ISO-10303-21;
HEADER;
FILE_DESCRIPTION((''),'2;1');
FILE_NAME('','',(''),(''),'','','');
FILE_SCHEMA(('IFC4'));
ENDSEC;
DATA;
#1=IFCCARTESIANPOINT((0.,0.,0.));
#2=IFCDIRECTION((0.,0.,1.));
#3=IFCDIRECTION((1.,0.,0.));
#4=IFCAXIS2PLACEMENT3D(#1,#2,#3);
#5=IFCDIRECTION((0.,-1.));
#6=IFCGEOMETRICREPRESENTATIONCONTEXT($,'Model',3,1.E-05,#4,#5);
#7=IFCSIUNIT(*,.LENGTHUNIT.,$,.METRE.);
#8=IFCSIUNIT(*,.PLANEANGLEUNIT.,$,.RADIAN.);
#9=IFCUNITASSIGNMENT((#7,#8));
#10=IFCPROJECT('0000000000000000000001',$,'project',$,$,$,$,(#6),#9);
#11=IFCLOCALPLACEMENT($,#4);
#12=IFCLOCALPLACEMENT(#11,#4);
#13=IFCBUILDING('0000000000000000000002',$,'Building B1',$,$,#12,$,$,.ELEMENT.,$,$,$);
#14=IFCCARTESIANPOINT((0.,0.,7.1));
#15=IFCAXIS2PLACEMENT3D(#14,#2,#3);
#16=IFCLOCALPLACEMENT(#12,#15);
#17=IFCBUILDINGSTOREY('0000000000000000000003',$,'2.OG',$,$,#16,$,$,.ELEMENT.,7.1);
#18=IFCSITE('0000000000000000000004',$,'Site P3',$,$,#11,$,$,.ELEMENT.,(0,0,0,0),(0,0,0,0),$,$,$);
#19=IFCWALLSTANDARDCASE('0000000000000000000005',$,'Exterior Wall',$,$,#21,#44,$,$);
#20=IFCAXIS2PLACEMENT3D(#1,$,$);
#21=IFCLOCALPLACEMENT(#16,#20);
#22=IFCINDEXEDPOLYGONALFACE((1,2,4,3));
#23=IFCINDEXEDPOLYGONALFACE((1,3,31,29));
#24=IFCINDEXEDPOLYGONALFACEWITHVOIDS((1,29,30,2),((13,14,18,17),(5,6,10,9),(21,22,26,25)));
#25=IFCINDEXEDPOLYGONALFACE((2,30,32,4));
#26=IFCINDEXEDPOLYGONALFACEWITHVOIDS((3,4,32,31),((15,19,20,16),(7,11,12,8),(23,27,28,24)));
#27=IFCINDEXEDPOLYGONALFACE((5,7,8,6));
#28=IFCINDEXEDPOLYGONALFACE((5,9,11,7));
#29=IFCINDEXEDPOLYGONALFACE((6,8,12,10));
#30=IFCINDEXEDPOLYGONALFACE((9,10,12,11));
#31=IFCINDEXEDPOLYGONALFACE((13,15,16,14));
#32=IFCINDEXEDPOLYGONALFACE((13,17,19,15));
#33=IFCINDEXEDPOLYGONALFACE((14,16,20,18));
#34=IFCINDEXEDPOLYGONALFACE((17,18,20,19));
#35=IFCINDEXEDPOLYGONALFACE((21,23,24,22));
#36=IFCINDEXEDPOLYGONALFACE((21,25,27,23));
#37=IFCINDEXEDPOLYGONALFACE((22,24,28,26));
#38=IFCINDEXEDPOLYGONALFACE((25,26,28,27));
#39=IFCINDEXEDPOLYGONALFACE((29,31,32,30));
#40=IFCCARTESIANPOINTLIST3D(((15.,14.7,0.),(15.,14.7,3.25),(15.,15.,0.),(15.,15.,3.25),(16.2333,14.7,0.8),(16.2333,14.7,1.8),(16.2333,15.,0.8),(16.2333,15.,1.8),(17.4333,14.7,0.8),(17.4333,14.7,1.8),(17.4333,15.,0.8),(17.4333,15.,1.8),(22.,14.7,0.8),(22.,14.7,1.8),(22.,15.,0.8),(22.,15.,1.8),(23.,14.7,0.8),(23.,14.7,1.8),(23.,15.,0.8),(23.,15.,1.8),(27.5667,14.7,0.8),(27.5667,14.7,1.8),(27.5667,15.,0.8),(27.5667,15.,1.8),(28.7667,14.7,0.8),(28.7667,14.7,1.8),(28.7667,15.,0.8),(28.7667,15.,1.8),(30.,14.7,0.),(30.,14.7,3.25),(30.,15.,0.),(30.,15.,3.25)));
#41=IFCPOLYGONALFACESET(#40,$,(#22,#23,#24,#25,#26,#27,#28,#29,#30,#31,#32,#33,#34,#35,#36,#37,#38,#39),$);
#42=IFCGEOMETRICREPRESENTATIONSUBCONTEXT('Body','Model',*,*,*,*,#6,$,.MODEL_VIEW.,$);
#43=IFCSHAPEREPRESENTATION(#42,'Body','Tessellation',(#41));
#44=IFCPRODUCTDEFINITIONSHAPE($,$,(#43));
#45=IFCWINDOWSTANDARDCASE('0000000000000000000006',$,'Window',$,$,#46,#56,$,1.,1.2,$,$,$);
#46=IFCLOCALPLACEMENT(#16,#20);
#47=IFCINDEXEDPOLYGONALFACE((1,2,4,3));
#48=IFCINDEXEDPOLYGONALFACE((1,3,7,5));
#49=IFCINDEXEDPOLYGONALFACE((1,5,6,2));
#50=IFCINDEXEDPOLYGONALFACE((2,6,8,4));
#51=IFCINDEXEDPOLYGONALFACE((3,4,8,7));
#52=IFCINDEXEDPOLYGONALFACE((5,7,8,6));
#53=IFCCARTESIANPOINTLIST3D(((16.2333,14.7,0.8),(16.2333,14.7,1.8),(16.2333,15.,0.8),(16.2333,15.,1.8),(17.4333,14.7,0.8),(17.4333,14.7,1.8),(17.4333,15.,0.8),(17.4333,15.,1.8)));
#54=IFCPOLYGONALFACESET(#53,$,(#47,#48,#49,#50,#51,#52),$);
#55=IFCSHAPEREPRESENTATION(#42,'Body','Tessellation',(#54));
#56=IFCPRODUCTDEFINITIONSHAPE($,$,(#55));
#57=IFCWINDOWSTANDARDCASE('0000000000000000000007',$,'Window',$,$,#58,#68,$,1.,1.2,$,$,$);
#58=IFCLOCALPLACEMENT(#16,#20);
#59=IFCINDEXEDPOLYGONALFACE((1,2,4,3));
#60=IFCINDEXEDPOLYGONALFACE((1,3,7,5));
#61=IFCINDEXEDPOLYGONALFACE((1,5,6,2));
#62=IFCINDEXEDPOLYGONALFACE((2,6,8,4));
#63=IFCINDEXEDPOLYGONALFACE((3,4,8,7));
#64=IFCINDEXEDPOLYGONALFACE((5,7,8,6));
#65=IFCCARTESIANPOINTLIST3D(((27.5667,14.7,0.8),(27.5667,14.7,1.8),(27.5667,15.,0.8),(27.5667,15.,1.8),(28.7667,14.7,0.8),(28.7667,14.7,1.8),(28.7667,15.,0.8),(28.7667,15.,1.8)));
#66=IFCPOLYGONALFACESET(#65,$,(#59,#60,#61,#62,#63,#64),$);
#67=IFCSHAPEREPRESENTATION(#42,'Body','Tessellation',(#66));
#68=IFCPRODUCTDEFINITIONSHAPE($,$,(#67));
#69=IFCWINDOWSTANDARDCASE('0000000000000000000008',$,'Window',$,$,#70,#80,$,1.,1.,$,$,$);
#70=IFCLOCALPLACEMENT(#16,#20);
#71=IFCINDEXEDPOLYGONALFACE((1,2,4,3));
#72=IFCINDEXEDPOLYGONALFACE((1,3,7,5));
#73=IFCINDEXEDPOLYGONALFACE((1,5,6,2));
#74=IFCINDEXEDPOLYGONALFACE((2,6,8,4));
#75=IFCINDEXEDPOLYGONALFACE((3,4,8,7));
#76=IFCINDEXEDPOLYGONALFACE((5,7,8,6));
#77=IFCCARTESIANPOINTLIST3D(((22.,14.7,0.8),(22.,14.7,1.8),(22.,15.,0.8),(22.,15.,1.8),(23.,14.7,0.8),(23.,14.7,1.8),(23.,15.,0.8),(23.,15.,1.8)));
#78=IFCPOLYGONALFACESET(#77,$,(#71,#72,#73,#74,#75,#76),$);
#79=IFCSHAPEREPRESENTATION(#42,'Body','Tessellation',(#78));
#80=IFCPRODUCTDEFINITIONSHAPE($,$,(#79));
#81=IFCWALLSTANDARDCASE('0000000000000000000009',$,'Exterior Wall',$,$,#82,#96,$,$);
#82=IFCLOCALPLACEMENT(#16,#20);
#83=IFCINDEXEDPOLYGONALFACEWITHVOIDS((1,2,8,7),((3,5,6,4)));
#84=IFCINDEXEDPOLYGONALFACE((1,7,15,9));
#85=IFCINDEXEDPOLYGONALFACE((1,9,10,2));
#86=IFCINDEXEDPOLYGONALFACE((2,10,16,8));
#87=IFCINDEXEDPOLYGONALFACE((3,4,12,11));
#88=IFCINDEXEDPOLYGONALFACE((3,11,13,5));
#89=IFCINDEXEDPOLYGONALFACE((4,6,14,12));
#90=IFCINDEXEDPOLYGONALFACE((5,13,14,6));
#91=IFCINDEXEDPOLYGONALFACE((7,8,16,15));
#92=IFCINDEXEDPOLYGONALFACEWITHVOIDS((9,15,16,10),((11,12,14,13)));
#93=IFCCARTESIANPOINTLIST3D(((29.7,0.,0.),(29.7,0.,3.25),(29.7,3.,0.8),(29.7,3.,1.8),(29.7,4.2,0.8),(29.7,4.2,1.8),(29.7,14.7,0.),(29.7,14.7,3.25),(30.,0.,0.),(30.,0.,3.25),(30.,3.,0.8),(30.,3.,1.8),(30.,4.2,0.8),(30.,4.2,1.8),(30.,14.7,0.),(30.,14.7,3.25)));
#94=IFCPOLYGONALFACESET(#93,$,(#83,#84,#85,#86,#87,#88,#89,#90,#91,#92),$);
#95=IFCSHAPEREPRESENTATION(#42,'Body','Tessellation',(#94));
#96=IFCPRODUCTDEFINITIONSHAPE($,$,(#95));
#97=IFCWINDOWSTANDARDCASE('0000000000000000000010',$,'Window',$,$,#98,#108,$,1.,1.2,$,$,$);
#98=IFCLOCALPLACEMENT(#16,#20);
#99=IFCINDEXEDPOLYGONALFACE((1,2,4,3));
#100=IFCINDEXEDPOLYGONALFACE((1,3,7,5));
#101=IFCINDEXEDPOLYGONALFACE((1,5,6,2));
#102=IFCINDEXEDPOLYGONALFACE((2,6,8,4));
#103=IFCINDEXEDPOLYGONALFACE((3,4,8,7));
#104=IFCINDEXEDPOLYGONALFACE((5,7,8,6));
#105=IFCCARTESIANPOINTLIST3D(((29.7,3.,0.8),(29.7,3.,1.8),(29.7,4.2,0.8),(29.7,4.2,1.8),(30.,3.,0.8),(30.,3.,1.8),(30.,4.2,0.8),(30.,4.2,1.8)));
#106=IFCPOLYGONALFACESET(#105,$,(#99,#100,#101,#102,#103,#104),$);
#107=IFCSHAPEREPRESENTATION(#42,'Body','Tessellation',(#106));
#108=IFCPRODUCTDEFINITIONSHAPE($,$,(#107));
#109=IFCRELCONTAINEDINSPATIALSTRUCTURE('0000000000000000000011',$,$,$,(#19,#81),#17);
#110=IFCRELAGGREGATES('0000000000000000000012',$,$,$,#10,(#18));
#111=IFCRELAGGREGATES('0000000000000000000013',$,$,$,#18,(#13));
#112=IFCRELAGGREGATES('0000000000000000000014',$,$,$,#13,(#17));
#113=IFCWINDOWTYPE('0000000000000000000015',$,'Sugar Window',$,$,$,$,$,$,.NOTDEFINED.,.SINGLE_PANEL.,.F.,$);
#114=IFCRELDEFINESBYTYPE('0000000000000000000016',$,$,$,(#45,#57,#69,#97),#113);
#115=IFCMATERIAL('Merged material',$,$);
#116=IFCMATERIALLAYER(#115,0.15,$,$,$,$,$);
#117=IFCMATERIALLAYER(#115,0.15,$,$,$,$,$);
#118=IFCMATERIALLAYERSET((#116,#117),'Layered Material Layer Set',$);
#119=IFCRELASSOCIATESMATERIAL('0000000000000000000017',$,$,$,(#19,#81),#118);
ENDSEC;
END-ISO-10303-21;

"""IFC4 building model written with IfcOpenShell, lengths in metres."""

from ifc_helpers import new_model, si_unit, direction, frame, origin_with_axes, place, context, subcontext, project, spatial, polyline, outline, extrude, source, transform, mapped, material, layer, layer_set, layer_usage, type_object, element, fill, save


model = new_model("IFC4")

# Units and contexts
model_context = context("Model", 3, precision=1e-05, world=origin_with_axes(), true_north=direction((0.0, -1.0)))
body_context = subcontext(model_context, "Body", "Model", "MODEL_VIEW")
ifc_project = project(units=[si_unit("LENGTHUNIT", "METRE"), si_unit("PLANEANGLEUNIT", "RADIAN")], contexts=[model_context])

# Site, building, storey
site_placement = place(None, origin_with_axes())
site = spatial("IfcSite", under=ifc_project, at=site_placement, Name="Site P3", CompositionType="ELEMENT", RefLatitude=(0, 0, 0, 0), RefLongitude=(0, 0, 0, 0))
building_placement = place(site_placement, origin_with_axes())
building = spatial("IfcBuilding", under=site, at=building_placement, Name="Building B1", CompositionType="ELEMENT")
storey_placement = place(building_placement, frame((0.0, 0.0, 7.1), z_axis=(0.0, 0.0, 1.0), x_axis=(1.0, 0.0, 0.0)))
storey = spatial("IfcBuildingStorey", under=building, at=storey_placement, Name="2.OG", CompositionType="ELEMENT", Elevation=7.1)

# Wall, openings, windows
ifc_material = material(Name="Merged material")
ifc_layer_1 = layer(ifc_material, 0.15)
ifc_layer_2 = layer(ifc_material, 0.15)
ifc_layer_set_1 = layer_set([ifc_layer_1, ifc_layer_2], Name="Layered Material Layer Set")
ifc_layer_usage_1 = layer_usage(ifc_layer_set_1, "AXIS2", "POSITIVE", -0.15)
wall_1_placement = place(storey_placement, frame((30.0, 14.85, 0.0), z_axis=(0.0, 0.0, 1.0), x_axis=(-1.0, 0.0, 0.0)))
wall_1 = element("IfcWallStandardCase", 1, at=wall_1_placement, inside=storey, material=ifc_layer_usage_1, Name="Exterior Wall", context=body_context, shape_type="SweptSolid", body=[
    extrude(outline(polyline([(0.0, 0.15), (15.0, 0.15), (15.0, -0.15), (0.0, -0.15), (0.0, 0.15)])), origin_with_axes(), (0.0, 0.0, 1.0), 3.25),
])
opening_1_placement = place(wall_1_placement, frame((12.5667, 0.0, 0.8), z_axis=(0.0, 0.0, 1.0), x_axis=(1.0, 0.0, 0.0)))
opening_1 = element("IfcOpeningStandardCase", 2, at=opening_1_placement, cuts=wall_1, context=body_context, shape_type="SweptSolid", body=[
    extrude(outline(polyline([(0.0, 0.0), (0.0, 1.2), (1.0, 1.2), (1.0, 0.0), (0.0, 0.0)])), frame((0.0, -0.15, 0.0), z_axis=(0.0, 1.0, 0.0), x_axis=(0.0, 0.0, 1.0)), (0.0, 0.0, 1.0), 0.3),
])
opening_2_placement = place(wall_1_placement, frame((7.0, 0.0, 0.8), z_axis=(0.0, 0.0, 1.0), x_axis=(1.0, 0.0, 0.0)))
opening_2 = element("IfcOpeningStandardCase", 3, at=opening_2_placement, cuts=wall_1, context=body_context, shape_type="SweptSolid", body=[
    extrude(outline(polyline([(0.0, 0.0), (0.0, 1.0), (1.0, 1.0), (1.0, 0.0), (0.0, 0.0)])), frame((0.0, -0.15, 0.0), z_axis=(0.0, 1.0, 0.0), x_axis=(0.0, 0.0, 1.0)), (0.0, 0.0, 1.0), 0.3),
])
opening_3_placement = place(wall_1_placement, frame((1.2333, 0.0, 0.8), z_axis=(0.0, 0.0, 1.0), x_axis=(1.0, 0.0, 0.0)))
opening_3 = element("IfcOpeningStandardCase", 4, at=opening_3_placement, cuts=wall_1, context=body_context, shape_type="SweptSolid", body=[
    extrude(outline(polyline([(0.0, 0.0), (0.0, 1.2), (1.0, 1.2), (1.0, 0.0), (0.0, 0.0)])), frame((0.0, -0.15, 0.0), z_axis=(0.0, 1.0, 0.0), x_axis=(0.0, 0.0, 1.0)), (0.0, 0.0, 1.0), 0.3),
])
window_type = type_object("IfcWindowType", Name="Sugar Window", ParameterTakesPrecedence=False, PartitioningType="SINGLE_PANEL", PredefinedType="NOTDEFINED")
shared_shape_1 = source(origin_with_axes(), body_context, "Body", "SweptSolid", [
    extrude(outline(polyline([(0.0, 0.0), (0.0, 1.2), (1.0, 1.2), (1.0, 0.0), (0.0, 0.0)])), frame((0.0, -0.15, 0.0), z_axis=(0.0, 1.0, 0.0), x_axis=(0.0, 0.0, 1.0)), (0.0, 0.0, 1.0), 0.3),
])
window_1_placement = place(opening_1_placement, origin_with_axes())
window_1 = element("IfcWindowStandardCase", 5, at=window_1_placement, type_object=window_type, Name="Window", OverallHeight=1.0, OverallWidth=1.2, context=body_context, shape_type="MappedRepresentation", body=[
    mapped(shared_shape_1, transform((0.0, 0.0, 0.0))),
])
fill(opening_1, window_1)
window_2_placement = place(opening_3_placement, origin_with_axes())
window_2 = element("IfcWindowStandardCase", 6, at=window_2_placement, type_object=window_type, Name="Window", OverallHeight=1.0, OverallWidth=1.2, context=body_context, shape_type="MappedRepresentation", body=[
    mapped(shared_shape_1, transform((0.0, 0.0, 0.0))),
])
fill(opening_3, window_2)
shared_shape_2 = source(origin_with_axes(), body_context, "Body", "SweptSolid", [
    extrude(outline(polyline([(0.0, 0.0), (0.0, 1.0), (1.0, 1.0), (1.0, 0.0), (0.0, 0.0)])), frame((0.0, -0.15, 0.0), z_axis=(0.0, 1.0, 0.0), x_axis=(0.0, 0.0, 1.0)), (0.0, 0.0, 1.0), 0.3),
])
window_3_placement = place(opening_2_placement, origin_with_axes())
window_3 = element("IfcWindowStandardCase", 7, at=window_3_placement, type_object=window_type, Name="Window", OverallHeight=1.0, OverallWidth=1.0, context=body_context, shape_type="MappedRepresentation", body=[
    mapped(shared_shape_2, transform((0.0, 0.0, 0.0))),
])
fill(opening_2, window_3)

# Wall, opening, window
wall_2_placement = place(storey_placement, frame((29.85, 0.0, 0.0), z_axis=(0.0, 0.0, 1.0), x_axis=(0.0, 1.0, 0.0)))
wall_2 = element("IfcWallStandardCase", 8, at=wall_2_placement, inside=storey, material=ifc_layer_usage_1, Name="Exterior Wall", context=body_context, shape_type="SweptSolid", body=[
    extrude(outline(polyline([(0.0, 0.15), (14.7, 0.15), (14.7, -0.15), (0.0, -0.15), (0.0, 0.15)])), origin_with_axes(), (0.0, 0.0, 1.0), 3.25),
])
opening_4_placement = place(wall_2_placement, frame((3.0, 0.0, 0.8), z_axis=(0.0, 0.0, 1.0), x_axis=(1.0, 0.0, 0.0)))
opening_4 = element("IfcOpeningStandardCase", 9, at=opening_4_placement, cuts=wall_2, context=body_context, shape_type="SweptSolid", body=[
    extrude(outline(polyline([(0.0, 0.0), (0.0, 1.2), (1.0, 1.2), (1.0, 0.0), (0.0, 0.0)])), frame((0.0, -0.15, 0.0), z_axis=(0.0, 1.0, 0.0), x_axis=(0.0, 0.0, 1.0)), (0.0, 0.0, 1.0), 0.3),
])
window_4_placement = place(opening_4_placement, origin_with_axes())
window_4 = element("IfcWindowStandardCase", 10, at=window_4_placement, type_object=window_type, Name="Window", OverallHeight=1.0, OverallWidth=1.2, context=body_context, shape_type="MappedRepresentation", body=[
    mapped(shared_shape_1, transform((0.0, 0.0, 0.0))),
])
fill(opening_4, window_4)

save(model, "model.ifc")
